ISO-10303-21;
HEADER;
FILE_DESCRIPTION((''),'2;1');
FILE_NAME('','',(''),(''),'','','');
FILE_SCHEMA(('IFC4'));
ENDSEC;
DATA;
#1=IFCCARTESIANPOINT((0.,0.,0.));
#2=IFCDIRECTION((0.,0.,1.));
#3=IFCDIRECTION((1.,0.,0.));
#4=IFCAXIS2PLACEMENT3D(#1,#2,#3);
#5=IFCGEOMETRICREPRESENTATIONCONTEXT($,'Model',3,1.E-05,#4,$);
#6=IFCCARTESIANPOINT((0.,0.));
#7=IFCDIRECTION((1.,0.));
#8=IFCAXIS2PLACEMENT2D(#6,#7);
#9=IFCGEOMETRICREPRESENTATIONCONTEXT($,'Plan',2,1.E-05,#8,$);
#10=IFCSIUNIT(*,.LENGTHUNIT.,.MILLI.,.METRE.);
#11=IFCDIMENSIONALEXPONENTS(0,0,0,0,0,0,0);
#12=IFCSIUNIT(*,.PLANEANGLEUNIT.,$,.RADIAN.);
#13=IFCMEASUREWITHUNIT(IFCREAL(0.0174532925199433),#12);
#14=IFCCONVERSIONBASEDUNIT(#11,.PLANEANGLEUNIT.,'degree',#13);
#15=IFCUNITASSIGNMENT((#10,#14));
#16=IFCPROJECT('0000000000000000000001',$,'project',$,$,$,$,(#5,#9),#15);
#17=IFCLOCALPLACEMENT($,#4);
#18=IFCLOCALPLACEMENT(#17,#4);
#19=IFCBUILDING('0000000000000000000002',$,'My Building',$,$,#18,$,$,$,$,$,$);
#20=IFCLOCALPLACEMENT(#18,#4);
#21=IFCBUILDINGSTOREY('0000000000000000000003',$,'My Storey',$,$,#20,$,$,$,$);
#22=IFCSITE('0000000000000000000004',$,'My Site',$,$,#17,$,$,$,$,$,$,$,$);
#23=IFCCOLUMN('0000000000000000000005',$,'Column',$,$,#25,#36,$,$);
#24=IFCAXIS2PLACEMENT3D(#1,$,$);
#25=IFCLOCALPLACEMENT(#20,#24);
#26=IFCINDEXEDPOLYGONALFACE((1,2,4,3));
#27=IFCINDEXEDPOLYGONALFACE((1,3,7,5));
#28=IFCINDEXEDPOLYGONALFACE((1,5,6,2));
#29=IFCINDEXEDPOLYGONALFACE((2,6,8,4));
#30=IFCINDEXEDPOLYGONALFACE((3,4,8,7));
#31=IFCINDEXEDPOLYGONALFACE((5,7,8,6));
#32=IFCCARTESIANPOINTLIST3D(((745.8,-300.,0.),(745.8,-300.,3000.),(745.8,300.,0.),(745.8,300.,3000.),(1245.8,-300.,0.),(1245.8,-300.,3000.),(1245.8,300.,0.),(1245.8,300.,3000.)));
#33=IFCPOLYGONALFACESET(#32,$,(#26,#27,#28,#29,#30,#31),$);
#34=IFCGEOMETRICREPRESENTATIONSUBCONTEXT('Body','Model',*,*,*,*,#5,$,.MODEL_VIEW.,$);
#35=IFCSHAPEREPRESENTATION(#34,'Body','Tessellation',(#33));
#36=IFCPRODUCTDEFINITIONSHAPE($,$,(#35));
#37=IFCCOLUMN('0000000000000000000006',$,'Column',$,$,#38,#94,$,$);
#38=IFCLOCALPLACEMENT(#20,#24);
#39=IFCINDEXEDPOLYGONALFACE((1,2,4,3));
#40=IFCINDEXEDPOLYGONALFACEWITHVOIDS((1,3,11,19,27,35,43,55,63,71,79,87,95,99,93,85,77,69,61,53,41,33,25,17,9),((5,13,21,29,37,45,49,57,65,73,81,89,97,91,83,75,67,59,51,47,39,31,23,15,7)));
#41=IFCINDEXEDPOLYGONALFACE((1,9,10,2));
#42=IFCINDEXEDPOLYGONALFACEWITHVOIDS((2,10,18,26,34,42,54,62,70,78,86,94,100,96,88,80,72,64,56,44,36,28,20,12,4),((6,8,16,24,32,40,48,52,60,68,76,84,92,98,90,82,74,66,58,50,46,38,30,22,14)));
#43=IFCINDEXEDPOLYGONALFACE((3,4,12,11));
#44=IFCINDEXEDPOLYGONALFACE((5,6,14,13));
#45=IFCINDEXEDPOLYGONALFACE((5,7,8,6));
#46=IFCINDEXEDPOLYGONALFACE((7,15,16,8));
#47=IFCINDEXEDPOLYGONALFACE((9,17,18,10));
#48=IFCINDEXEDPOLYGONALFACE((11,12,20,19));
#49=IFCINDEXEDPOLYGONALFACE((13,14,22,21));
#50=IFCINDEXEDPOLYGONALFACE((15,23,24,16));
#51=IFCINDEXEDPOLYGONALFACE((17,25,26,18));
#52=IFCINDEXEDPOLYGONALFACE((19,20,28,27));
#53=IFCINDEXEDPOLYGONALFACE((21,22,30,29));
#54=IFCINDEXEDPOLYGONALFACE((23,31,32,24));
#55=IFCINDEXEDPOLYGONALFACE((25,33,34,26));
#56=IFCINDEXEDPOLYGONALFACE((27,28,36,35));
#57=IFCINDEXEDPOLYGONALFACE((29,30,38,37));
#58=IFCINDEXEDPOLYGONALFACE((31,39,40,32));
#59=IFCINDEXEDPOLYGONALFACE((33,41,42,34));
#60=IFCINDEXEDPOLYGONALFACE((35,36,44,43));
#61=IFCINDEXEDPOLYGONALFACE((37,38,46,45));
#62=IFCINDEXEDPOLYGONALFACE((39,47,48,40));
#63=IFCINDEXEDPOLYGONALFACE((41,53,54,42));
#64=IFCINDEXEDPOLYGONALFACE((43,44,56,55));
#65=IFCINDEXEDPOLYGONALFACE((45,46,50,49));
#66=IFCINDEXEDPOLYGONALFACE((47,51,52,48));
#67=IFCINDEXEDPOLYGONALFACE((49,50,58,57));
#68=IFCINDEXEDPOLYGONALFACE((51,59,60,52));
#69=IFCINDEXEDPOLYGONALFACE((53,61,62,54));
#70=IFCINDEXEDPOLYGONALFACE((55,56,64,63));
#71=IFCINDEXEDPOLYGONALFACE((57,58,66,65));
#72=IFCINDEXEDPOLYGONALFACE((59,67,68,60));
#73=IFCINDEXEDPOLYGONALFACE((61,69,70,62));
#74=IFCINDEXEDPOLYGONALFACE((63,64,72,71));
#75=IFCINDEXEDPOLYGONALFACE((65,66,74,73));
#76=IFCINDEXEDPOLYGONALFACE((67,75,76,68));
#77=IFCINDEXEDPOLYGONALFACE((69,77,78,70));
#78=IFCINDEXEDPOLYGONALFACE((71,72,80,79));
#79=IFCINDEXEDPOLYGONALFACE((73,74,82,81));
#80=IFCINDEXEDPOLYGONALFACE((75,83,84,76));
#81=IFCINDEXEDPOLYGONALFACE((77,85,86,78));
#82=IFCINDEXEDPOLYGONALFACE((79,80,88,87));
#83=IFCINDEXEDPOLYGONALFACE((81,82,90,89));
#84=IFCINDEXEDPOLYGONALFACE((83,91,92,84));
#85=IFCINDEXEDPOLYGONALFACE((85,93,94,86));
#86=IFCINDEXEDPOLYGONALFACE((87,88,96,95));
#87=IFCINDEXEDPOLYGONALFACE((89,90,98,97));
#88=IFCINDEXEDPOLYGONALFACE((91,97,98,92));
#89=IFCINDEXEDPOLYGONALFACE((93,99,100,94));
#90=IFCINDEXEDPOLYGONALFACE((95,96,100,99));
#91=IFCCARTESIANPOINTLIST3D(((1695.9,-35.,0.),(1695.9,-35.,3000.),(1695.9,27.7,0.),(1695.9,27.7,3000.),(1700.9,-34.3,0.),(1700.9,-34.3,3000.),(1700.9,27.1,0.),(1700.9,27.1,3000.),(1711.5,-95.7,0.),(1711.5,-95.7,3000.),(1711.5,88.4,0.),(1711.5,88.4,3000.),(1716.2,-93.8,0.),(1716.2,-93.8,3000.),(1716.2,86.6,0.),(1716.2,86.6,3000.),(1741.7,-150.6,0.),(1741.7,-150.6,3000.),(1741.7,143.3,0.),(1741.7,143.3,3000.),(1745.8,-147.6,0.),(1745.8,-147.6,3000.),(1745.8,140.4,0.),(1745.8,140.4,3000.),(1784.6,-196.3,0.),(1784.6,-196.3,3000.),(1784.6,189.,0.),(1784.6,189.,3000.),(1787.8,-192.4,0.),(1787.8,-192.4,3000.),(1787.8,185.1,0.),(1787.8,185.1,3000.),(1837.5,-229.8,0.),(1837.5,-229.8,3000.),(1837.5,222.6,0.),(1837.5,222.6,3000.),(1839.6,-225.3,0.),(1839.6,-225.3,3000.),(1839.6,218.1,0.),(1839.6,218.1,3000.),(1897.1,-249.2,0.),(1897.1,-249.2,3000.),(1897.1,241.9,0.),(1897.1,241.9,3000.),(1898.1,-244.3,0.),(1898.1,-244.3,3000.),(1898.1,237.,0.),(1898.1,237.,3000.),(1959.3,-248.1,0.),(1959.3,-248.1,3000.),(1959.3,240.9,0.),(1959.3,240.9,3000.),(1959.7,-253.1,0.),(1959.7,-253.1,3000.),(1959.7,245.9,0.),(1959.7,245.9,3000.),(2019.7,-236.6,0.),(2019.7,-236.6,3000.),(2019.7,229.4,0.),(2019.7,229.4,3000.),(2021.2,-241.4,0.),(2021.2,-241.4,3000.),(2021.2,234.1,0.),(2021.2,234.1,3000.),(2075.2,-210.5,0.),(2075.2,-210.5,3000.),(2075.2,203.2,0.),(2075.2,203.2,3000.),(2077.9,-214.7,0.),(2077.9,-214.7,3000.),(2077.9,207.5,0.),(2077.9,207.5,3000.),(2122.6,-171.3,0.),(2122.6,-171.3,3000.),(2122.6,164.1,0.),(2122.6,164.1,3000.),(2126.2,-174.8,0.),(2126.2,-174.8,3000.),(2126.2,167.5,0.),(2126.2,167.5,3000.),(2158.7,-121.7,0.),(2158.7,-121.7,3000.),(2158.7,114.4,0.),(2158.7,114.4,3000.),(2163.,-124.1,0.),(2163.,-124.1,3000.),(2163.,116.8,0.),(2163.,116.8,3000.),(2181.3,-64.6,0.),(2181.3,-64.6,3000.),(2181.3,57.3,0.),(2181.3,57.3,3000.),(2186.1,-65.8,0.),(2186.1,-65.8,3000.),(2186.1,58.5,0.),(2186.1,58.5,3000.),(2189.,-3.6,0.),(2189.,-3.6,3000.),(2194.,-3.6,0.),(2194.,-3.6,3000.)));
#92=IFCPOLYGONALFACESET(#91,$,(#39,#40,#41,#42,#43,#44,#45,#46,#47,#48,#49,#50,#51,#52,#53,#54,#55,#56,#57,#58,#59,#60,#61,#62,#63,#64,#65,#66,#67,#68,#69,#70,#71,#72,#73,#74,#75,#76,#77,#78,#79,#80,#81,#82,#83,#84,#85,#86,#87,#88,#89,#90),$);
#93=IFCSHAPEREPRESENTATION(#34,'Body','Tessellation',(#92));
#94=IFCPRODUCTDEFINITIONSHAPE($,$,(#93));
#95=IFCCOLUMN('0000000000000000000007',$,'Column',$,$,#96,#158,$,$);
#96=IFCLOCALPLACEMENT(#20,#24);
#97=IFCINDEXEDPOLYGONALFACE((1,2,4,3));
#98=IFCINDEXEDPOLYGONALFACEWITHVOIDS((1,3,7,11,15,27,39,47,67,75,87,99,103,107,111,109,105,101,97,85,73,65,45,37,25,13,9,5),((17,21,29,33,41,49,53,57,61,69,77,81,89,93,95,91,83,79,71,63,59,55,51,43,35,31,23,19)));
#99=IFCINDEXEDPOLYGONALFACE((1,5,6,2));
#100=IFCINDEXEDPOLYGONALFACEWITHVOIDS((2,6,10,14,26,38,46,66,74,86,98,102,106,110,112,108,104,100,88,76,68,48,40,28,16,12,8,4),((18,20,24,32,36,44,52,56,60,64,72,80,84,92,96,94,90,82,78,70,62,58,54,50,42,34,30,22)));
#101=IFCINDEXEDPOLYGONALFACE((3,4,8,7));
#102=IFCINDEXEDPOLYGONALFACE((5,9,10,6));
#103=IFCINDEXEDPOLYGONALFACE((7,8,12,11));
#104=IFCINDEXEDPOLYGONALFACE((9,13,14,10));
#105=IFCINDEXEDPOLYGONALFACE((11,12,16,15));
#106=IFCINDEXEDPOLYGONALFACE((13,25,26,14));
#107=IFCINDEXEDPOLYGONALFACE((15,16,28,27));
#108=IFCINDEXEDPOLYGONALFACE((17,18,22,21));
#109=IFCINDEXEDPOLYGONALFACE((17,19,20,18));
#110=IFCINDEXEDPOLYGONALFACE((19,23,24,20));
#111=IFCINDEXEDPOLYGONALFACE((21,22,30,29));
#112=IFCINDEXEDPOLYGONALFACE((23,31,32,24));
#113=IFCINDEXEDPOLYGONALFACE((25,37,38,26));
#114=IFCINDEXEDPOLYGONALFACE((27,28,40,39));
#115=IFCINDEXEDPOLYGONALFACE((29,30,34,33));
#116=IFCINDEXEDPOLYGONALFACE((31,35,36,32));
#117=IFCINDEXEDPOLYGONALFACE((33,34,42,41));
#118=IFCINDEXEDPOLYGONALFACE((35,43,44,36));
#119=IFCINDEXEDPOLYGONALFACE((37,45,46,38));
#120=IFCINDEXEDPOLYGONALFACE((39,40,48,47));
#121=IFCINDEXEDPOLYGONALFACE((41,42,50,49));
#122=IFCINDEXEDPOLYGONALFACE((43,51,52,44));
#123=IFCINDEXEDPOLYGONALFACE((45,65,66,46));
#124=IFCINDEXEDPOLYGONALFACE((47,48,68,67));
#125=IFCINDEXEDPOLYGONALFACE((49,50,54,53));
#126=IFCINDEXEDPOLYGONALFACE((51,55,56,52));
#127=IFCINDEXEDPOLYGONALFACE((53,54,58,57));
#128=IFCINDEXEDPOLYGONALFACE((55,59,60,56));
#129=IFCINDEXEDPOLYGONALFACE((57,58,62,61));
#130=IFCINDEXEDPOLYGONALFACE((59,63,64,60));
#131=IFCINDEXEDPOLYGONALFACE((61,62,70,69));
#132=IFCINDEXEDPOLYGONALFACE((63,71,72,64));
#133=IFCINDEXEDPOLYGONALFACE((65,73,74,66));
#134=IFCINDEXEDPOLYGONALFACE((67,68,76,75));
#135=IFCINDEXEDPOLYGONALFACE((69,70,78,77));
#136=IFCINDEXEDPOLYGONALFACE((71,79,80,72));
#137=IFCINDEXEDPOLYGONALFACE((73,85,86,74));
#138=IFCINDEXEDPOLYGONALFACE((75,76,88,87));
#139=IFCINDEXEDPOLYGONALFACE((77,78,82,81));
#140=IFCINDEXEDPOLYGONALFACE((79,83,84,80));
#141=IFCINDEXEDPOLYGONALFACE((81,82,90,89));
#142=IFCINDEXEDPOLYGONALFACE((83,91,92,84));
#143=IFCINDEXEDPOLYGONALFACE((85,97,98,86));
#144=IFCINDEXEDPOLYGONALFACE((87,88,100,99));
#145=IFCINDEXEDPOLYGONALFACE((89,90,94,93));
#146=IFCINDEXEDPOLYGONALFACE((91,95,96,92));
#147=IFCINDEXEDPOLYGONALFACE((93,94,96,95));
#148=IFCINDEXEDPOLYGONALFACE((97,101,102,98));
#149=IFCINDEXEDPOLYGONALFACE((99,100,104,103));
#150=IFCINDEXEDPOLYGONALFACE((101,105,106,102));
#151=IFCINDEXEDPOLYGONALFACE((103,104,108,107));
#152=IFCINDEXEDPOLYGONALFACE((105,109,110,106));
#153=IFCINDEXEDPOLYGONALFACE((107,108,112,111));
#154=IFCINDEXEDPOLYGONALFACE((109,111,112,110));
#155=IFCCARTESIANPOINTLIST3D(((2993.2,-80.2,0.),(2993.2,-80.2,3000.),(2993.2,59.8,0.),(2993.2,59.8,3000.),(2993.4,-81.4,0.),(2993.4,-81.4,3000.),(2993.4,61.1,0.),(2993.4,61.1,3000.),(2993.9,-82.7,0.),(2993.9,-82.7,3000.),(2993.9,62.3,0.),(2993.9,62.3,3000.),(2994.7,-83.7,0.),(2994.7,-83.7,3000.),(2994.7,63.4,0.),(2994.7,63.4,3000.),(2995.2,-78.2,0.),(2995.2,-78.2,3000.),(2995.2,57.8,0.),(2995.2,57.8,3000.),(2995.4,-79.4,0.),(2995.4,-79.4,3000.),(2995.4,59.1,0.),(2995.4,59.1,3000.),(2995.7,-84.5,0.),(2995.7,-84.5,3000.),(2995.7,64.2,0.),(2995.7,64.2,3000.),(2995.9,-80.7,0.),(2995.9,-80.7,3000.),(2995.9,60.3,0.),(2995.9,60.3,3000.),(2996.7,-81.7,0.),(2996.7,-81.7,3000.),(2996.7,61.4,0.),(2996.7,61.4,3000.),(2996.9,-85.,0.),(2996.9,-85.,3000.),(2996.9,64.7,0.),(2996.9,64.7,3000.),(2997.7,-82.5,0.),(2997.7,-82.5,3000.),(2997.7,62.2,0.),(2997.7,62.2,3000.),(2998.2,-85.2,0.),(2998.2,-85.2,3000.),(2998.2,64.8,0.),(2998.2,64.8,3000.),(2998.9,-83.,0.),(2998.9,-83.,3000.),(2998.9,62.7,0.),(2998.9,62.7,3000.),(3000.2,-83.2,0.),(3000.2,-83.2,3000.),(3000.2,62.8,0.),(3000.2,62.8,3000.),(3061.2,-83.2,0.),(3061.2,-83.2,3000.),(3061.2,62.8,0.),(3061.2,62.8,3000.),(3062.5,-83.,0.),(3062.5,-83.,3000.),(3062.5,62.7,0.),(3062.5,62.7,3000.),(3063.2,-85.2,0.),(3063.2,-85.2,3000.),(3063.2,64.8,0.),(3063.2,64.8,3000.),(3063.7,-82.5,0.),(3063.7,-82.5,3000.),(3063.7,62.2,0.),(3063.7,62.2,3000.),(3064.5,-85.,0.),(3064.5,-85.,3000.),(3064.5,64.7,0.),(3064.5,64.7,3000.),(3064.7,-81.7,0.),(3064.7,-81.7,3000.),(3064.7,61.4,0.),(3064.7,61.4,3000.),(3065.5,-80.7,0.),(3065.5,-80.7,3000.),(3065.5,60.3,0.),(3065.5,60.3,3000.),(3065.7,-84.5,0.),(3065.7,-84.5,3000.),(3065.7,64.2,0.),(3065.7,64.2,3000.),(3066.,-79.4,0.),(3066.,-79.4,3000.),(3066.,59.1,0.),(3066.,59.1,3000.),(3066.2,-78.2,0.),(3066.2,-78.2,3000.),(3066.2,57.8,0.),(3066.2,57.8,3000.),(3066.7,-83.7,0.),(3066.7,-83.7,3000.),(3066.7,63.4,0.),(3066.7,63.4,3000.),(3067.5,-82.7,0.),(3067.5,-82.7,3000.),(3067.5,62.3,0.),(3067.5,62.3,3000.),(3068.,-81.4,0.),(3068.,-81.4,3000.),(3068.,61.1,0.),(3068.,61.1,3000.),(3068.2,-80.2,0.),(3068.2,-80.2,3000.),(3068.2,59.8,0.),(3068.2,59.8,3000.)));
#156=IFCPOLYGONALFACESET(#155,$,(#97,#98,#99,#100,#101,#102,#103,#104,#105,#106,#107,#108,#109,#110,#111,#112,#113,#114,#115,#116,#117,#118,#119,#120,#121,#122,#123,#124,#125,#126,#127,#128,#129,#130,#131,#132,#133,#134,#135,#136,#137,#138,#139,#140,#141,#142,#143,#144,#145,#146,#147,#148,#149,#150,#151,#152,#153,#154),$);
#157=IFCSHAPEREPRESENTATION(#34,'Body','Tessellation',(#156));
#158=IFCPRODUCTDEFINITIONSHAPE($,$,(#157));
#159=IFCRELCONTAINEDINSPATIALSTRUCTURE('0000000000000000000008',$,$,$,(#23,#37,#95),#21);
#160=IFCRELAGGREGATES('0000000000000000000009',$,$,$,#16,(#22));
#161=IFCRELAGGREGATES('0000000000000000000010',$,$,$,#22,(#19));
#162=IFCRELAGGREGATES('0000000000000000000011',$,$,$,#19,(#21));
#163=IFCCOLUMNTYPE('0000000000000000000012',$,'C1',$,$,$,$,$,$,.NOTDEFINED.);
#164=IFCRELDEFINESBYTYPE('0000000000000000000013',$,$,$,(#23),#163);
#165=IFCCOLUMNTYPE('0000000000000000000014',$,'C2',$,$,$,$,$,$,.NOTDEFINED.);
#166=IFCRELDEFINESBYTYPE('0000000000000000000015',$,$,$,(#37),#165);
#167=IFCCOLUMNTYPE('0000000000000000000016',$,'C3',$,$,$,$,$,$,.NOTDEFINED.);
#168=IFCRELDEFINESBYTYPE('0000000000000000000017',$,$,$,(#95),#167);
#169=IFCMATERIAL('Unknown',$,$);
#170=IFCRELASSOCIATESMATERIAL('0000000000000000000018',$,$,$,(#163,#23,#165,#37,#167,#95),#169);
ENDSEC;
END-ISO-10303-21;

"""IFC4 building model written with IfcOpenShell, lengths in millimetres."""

from ifc_helpers import new_model, entity, si_unit, converted_unit, frame, origin_with_axes, origin_2d_with_axis, place, context, subcontext, project, spatial, rectangle, hollow_rectangle, hollow_circle, extrude, material, material_profile, profile_set, profile_usage, type_object, element, save


model = new_model("IFC4")

# Units and contexts
model_context = context("Model", 3, precision=1e-05, world=origin_with_axes())
plan_context = context("Plan", 2, precision=1e-05, world=origin_2d_with_axis())
body_context = subcontext(model_context, "Body", "Model", "MODEL_VIEW")
ifc_project = project(units=[si_unit("LENGTHUNIT", "METRE", prefix="MILLI"), converted_unit("PLANEANGLEUNIT", "degree", entity("IfcReal", 0.0174532925199433), si_unit("PLANEANGLEUNIT", "RADIAN"), dimensions=[0, 0, 0, 0, 0, 0, 0])], contexts=[model_context, plan_context])

# Site, building, storey
site_placement = place(None, origin_with_axes())
site = spatial("IfcSite", under=ifc_project, at=site_placement, Name="My Site")
building_placement = place(site_placement, origin_with_axes())
building = spatial("IfcBuilding", under=site, at=building_placement, Name="My Building")
storey_placement = place(building_placement, origin_with_axes())
storey = spatial("IfcBuildingStorey", under=building, at=storey_placement, Name="My Storey")

# Columns
ifc_material = material(Name="Unknown")
ifc_material_profile_1 = material_profile(ifc_material, rectangle(XDim=500.0, YDim=600.0))
ifc_profile_set_1 = profile_set([ifc_material_profile_1])
ifc_profile_usage_1 = profile_usage(ifc_profile_set_1, cardinal=5)
column_type_1 = type_object("IfcColumnType", Name="C1", PredefinedType="NOTDEFINED", material=ifc_profile_set_1)
column_1_placement = place(storey_placement, frame((995.8, 0.0, 0.0), z_axis=(0.0, 0.0, 1.0), x_axis=(1.0, 0.0, 0.0)))
element("IfcColumn", 1, at=column_1_placement, inside=storey, type_object=column_type_1, material=ifc_profile_usage_1, Name="Column", context=body_context, shape_type="SweptSolid", body=[
    extrude(rectangle(XDim=500.0, YDim=600.0), origin_with_axes(), (0.0, 0.0, 1.0), 3000.0),
])
ifc_material_profile_2 = material_profile(ifc_material, hollow_circle(Radius=250.0, WallThickness=5.0))
ifc_profile_set_2 = profile_set([ifc_material_profile_2])
ifc_profile_usage_2 = profile_usage(ifc_profile_set_2, cardinal=5)
column_type_2 = type_object("IfcColumnType", Name="C2", PredefinedType="NOTDEFINED", material=ifc_profile_set_2)
column_2_placement = place(storey_placement, frame((1944.0, -3.6, 0.0), z_axis=(0.0, 0.0, 1.0), x_axis=(1.0, 0.0, 0.0)))
element("IfcColumn", 2, at=column_2_placement, inside=storey, type_object=column_type_2, material=ifc_profile_usage_2, Name="Column", context=body_context, shape_type="SweptSolid", body=[
    extrude(hollow_circle(Radius=250.0, WallThickness=5.0), origin_with_axes(), (0.0, 0.0, 1.0), 3000.0),
])
ifc_material_profile_3 = material_profile(ifc_material, hollow_rectangle(XDim=75.0, YDim=150.0, WallThickness=2.0, InnerFilletRadius=5.0, OuterFilletRadius=5.0))
ifc_profile_set_3 = profile_set([ifc_material_profile_3])
ifc_profile_usage_3 = profile_usage(ifc_profile_set_3, cardinal=5)
column_type_3 = type_object("IfcColumnType", Name="C3", PredefinedType="NOTDEFINED", material=ifc_profile_set_3)
column_3_placement = place(storey_placement, frame((3030.7, -10.2, 0.0), z_axis=(0.0, 0.0, 1.0), x_axis=(1.0, 0.0, 0.0)))
element("IfcColumn", 3, at=column_3_placement, inside=storey, type_object=column_type_3, material=ifc_profile_usage_3, Name="Column", context=body_context, shape_type="SweptSolid", body=[
    extrude(hollow_rectangle(XDim=75.0, YDim=150.0, WallThickness=2.0, InnerFilletRadius=5.0, OuterFilletRadius=5.0), origin_with_axes(), (0.0, 0.0, 1.0), 3000.0),
])

save(model, "model.ifc")
